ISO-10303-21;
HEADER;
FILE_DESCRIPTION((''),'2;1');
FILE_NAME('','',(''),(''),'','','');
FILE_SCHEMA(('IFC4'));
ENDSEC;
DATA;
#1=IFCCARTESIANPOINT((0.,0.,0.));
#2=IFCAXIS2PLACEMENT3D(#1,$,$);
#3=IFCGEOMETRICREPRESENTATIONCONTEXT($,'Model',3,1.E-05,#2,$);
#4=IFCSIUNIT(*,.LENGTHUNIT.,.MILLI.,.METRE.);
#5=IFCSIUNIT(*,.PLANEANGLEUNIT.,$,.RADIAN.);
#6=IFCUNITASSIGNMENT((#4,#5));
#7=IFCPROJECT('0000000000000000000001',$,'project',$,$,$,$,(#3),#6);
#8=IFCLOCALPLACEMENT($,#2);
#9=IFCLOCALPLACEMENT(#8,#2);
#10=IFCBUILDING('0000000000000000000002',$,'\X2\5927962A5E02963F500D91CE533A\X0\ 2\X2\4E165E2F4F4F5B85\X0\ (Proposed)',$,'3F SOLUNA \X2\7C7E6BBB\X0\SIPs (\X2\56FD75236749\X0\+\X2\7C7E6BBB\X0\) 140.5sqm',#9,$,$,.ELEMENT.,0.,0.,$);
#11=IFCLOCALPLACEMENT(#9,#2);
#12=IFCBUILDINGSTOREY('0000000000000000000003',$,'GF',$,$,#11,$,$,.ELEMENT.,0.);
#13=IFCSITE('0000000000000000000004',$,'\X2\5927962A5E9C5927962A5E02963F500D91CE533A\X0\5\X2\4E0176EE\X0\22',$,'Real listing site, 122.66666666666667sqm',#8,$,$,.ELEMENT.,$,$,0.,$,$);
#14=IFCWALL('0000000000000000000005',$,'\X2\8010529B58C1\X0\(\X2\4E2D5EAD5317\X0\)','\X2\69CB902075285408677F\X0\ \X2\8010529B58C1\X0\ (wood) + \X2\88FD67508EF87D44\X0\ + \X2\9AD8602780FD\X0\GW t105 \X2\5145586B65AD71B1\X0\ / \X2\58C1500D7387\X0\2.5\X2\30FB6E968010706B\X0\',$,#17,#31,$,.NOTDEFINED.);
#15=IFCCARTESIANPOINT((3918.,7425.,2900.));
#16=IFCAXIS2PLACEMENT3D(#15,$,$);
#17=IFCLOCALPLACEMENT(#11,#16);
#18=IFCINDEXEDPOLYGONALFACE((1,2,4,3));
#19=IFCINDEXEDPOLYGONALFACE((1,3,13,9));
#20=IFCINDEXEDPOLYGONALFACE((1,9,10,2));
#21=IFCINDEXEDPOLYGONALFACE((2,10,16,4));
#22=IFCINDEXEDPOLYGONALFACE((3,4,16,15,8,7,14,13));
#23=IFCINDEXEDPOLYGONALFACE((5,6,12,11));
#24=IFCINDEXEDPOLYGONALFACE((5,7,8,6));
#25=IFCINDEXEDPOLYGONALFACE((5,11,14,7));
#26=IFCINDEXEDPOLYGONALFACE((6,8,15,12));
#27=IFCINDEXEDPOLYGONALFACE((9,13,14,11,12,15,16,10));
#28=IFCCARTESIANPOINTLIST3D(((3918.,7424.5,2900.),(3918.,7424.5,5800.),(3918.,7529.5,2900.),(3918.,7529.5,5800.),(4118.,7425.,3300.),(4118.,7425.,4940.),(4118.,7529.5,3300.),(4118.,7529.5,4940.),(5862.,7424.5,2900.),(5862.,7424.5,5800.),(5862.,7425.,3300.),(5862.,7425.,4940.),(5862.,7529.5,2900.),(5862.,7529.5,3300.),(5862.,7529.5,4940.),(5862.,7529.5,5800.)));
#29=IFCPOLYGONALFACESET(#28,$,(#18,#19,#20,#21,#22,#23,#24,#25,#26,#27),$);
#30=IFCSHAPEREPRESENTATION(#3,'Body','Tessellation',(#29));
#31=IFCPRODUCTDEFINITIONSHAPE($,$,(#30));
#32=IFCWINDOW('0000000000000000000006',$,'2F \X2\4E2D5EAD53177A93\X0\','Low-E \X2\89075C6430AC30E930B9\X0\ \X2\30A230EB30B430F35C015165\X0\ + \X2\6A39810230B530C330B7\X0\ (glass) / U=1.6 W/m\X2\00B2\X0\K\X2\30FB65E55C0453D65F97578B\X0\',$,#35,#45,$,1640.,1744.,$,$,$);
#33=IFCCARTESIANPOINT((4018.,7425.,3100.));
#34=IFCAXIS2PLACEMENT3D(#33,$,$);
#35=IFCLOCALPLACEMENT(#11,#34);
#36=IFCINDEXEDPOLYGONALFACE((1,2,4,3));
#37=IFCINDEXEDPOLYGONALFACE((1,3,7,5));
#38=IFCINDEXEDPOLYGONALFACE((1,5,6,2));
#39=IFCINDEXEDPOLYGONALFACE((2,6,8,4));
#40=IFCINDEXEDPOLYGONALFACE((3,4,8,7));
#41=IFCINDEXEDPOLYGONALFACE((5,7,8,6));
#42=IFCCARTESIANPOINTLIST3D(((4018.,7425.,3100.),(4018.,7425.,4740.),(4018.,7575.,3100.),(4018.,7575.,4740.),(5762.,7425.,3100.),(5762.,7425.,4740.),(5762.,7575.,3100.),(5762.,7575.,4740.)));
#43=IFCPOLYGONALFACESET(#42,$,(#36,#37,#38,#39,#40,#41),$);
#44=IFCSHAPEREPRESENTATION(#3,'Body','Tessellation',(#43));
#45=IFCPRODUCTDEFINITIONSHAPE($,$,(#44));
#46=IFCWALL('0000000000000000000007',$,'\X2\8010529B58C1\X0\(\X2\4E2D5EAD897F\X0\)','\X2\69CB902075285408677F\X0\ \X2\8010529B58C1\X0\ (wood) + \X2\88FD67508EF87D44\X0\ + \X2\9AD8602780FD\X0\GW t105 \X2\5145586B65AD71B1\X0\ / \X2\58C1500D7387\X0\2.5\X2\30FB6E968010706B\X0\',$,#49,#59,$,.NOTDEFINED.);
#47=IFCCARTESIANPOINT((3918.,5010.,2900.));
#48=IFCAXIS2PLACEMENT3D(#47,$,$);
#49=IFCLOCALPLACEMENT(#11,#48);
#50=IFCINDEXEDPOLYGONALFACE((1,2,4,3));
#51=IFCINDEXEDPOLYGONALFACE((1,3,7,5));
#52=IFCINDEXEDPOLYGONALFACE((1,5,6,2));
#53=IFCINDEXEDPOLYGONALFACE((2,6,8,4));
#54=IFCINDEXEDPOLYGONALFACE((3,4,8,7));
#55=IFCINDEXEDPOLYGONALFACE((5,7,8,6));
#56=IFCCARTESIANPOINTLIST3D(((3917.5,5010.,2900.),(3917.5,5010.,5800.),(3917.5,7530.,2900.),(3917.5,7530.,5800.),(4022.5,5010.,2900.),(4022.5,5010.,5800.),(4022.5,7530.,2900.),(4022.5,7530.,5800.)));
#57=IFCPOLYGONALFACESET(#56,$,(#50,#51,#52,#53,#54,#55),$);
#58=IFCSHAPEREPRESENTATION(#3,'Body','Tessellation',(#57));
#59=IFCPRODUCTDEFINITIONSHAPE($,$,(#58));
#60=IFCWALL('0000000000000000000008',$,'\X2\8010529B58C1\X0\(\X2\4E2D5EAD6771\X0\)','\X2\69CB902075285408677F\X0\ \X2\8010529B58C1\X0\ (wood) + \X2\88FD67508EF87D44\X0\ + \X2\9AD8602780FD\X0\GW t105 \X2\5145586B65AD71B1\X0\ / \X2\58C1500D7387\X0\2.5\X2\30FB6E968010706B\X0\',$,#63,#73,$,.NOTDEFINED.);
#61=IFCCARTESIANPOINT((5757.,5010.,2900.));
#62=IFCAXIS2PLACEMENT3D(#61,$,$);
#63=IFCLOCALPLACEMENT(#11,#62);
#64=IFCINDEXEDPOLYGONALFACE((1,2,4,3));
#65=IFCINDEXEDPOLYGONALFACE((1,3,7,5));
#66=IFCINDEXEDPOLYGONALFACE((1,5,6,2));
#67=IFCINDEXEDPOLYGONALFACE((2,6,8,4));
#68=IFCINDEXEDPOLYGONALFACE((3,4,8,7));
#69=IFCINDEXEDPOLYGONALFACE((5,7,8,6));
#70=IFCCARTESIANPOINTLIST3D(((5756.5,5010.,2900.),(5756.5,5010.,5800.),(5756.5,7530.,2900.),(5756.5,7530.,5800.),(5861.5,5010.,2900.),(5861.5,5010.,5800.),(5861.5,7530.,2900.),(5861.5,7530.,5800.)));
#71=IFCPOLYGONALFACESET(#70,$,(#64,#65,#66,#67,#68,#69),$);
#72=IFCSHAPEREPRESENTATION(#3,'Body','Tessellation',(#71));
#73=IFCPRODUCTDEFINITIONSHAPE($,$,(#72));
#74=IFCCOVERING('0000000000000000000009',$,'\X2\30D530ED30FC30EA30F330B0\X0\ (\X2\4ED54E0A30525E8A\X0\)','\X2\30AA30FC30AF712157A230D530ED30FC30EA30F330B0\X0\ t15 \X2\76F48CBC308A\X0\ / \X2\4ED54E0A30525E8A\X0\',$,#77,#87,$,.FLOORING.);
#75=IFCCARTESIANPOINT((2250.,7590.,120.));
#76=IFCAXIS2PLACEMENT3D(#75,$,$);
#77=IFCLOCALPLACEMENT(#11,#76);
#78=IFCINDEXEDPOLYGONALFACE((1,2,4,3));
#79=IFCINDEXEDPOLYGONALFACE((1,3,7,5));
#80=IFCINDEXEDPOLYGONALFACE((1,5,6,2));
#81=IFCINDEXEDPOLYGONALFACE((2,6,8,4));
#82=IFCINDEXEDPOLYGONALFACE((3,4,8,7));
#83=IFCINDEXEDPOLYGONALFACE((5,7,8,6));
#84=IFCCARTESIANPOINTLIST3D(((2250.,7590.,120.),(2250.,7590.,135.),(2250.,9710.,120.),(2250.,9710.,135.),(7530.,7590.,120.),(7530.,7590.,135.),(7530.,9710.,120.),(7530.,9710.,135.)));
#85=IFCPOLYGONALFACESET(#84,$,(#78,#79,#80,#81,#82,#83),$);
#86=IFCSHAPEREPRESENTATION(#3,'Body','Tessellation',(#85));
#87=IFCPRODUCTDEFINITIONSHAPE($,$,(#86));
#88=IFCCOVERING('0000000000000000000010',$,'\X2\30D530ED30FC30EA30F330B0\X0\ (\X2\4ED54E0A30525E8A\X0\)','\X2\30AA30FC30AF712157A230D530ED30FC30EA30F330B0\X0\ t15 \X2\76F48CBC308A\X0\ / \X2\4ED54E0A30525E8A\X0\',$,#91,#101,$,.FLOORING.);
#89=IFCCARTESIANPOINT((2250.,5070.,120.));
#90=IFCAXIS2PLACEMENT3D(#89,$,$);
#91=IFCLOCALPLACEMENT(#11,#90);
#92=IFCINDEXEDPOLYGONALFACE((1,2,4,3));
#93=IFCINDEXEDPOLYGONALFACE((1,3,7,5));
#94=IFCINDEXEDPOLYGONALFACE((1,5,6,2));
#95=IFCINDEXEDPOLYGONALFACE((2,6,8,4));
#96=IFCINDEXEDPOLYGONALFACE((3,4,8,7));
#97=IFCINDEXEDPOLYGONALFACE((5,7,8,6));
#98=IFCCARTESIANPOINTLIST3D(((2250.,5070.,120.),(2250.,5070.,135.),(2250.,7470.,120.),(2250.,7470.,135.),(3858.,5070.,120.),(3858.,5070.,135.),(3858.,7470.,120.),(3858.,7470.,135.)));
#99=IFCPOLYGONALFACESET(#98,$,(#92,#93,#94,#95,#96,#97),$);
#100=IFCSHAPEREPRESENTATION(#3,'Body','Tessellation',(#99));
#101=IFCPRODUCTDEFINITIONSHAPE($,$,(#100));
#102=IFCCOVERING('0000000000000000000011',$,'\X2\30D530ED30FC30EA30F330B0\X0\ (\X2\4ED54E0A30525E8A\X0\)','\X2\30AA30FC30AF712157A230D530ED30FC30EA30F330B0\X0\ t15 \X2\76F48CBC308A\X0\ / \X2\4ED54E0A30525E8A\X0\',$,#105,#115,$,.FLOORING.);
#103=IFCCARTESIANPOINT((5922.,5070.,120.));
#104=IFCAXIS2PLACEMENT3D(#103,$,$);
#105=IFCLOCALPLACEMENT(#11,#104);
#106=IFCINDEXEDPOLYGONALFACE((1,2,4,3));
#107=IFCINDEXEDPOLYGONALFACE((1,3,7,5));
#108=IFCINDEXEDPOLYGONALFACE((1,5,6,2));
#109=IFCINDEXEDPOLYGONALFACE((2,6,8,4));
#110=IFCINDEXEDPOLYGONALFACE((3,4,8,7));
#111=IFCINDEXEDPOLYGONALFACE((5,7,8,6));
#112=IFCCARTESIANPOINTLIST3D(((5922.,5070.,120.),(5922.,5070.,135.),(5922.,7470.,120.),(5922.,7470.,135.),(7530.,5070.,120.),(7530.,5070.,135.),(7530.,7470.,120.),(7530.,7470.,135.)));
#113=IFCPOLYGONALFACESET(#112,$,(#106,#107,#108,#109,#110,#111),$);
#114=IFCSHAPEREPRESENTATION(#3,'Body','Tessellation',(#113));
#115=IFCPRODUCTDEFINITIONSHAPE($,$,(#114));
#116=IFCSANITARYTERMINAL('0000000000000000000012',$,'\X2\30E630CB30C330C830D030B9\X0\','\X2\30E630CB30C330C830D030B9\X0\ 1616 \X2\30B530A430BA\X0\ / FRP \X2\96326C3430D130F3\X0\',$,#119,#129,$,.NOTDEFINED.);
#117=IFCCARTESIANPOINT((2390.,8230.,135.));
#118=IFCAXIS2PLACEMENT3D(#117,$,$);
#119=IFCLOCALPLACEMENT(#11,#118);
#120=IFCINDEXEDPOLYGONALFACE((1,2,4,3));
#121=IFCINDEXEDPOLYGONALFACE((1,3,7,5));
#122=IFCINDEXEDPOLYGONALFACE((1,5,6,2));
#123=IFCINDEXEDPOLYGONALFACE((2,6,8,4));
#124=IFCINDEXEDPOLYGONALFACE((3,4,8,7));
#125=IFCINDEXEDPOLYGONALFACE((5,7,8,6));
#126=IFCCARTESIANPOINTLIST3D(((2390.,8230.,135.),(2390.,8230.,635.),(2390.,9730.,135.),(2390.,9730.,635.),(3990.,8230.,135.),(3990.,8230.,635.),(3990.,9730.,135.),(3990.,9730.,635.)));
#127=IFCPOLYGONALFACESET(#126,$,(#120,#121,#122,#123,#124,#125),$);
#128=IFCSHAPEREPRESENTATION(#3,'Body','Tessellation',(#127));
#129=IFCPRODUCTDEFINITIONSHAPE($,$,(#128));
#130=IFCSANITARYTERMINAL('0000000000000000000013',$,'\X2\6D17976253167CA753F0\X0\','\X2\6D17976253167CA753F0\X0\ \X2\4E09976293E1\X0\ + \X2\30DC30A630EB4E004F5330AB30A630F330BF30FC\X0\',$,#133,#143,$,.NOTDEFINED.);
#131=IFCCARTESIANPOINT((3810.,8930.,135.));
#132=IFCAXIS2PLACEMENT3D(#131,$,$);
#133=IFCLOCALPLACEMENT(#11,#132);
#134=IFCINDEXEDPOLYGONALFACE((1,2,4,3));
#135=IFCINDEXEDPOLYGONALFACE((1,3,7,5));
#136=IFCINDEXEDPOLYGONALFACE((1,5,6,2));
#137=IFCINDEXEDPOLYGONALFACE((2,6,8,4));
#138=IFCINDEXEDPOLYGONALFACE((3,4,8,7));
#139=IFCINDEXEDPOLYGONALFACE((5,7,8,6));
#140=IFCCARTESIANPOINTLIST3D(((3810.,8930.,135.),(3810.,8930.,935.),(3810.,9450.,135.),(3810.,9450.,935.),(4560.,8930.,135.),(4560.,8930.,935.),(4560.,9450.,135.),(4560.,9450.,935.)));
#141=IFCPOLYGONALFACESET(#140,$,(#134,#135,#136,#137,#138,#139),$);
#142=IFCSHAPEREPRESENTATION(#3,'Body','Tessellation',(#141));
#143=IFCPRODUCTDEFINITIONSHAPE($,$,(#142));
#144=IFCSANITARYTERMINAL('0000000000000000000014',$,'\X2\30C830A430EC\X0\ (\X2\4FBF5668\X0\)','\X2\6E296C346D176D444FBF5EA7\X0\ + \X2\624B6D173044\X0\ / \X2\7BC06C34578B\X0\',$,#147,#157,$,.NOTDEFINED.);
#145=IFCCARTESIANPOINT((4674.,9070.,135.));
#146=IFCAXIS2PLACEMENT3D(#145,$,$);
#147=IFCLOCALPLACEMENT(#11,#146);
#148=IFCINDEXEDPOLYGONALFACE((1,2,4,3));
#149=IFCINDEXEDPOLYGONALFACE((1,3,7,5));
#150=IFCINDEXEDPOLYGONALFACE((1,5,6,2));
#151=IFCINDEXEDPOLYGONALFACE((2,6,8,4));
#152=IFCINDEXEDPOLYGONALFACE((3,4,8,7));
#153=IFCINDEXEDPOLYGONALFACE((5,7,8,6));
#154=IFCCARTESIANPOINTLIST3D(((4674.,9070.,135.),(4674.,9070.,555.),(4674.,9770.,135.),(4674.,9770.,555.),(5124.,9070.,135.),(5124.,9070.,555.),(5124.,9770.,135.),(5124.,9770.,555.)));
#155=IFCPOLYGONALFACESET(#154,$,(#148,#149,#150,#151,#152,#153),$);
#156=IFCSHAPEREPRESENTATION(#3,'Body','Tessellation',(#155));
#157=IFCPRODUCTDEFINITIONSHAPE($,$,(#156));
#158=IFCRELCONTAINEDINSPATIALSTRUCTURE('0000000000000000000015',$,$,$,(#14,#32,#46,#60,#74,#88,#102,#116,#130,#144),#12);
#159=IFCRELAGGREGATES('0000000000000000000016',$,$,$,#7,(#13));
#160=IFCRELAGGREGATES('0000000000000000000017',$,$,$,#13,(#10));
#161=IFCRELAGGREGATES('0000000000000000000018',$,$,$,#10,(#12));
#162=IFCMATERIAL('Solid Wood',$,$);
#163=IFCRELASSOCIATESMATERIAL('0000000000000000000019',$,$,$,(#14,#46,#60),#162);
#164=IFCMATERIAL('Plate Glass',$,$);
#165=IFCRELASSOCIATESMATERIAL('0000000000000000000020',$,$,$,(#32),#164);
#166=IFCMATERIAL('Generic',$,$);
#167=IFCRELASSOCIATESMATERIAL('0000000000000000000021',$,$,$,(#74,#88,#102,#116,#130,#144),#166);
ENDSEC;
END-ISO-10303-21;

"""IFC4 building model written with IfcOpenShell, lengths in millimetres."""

from ifc_helpers import new_model, si_unit, frame, frame_2d, origin, place, context, project, spatial, rectangle, extrude, material, element, fill, save


model = new_model("IFC4")

# Units and contexts
model_context = context("Model", 3, precision=1e-05, world=origin())
ifc_project = project(units=[si_unit("LENGTHUNIT", "METRE", prefix="MILLI"), si_unit("PLANEANGLEUNIT", "RADIAN")], contexts=[model_context])

# Site, building, storey
site_placement = place(None, origin())
site = spatial("IfcSite", under=ifc_project, at=site_placement, Name="大阪府大阪市阿倍野区5丁目22", ObjectType="Real listing site, 122.66666666666667sqm", CompositionType="ELEMENT", RefElevation=0.0)
building_placement = place(site_placement, origin())
building = spatial("IfcBuilding", under=site, at=building_placement, Name="大阪市阿倍野区 2世帯住宅 (Proposed)", ObjectType="3F SOLUNA 籾殻SIPs (国産杉+籾殻) 140.5sqm", CompositionType="ELEMENT", ElevationOfRefHeight=0.0, ElevationOfTerrain=0.0)
storey_placement = place(building_placement, origin())
storey = spatial("IfcBuildingStorey", under=building, at=storey_placement, Name="GF", CompositionType="ELEMENT", Elevation=0.0)

# Shared definitions
ifc_material_1 = material(Name="Solid Wood")

# Shared definitions
ifc_material_2 = material(Name="Plate Glass")

# Wall, opening, window
wall_1_placement = place(storey_placement, frame((3918.0, 7425.0, 2900.0)))
wall_1 = element("IfcWall", 1, at=wall_1_placement, inside=storey, material=ifc_material_1, Name="耐力壁(中庭北)", Description="構造用合板 耐力壁 (wood) + 製材軸組 + 高性能GW t105 充填断熱 / 壁倍率2.5・準耐火", PredefinedType="NOTDEFINED", context=model_context, shape_type="SweptSolid", body=[
    extrude(rectangle(XDim=1944.0, YDim=105.0, at=frame_2d((972.0, 52.0))), frame((3918.0, 7425.0, 2900.0)), (0.0, 0.0, 1.0), 2900.0),
])
opening_1_placement = place(storey_placement, frame((4018.0, 7425.0, 3100.0)))
opening_1 = element("IfcOpeningElement", 2, at=opening_1_placement, cuts=wall_1, PredefinedType="NOTDEFINED", context=model_context, shape_type="SweptSolid", body=[
    extrude(rectangle(XDim=1744.0, YDim=150.0, at=frame_2d((872.0, 75.0))), frame((4018.0, 7425.0, 3100.0)), (0.0, 0.0, 1.0), 1640.0),
])
window_1_placement = place(storey_placement, frame((4018.0, 7425.0, 3100.0)))
window_1 = element("IfcWindow", 3, at=window_1_placement, inside=storey, material=ifc_material_2, Name="2F 中庭北窓", Description="Low-E 複層ガラス アルゴン封入 + 樹脂サッシ (glass) / U=1.6 W/m²K・日射取得型", OverallHeight=1640.0, OverallWidth=1744.0, context=model_context, shape_type="SweptSolid", body=[
    extrude(rectangle(XDim=1744.0, YDim=150.0, at=frame_2d((872.0, 75.0))), frame((4018.0, 7425.0, 3100.0)), (0.0, 0.0, 1.0), 1640.0),
])
fill(opening_1, window_1)

# Walls
wall_2_placement = place(storey_placement, frame((3918.0, 5010.0, 2900.0)))
element("IfcWall", 4, at=wall_2_placement, inside=storey, material=ifc_material_1, Name="耐力壁(中庭西)", Description="構造用合板 耐力壁 (wood) + 製材軸組 + 高性能GW t105 充填断熱 / 壁倍率2.5・準耐火", PredefinedType="NOTDEFINED", context=model_context, shape_type="SweptSolid", body=[
    extrude(rectangle(XDim=105.0, YDim=2520.0, at=frame_2d((52.0, 1260.0))), frame((3918.0, 5010.0, 2900.0)), (0.0, 0.0, 1.0), 2900.0),
])
wall_3_placement = place(storey_placement, frame((5757.0, 5010.0, 2900.0)))
element("IfcWall", 5, at=wall_3_placement, inside=storey, material=ifc_material_1, Name="耐力壁(中庭東)", Description="構造用合板 耐力壁 (wood) + 製材軸組 + 高性能GW t105 充填断熱 / 壁倍率2.5・準耐火", PredefinedType="NOTDEFINED", context=model_context, shape_type="SweptSolid", body=[
    extrude(rectangle(XDim=105.0, YDim=2520.0, at=frame_2d((52.0, 1260.0))), frame((5757.0, 5010.0, 2900.0)), (0.0, 0.0, 1.0), 2900.0),
])

# Coverings
ifc_material_3 = material(Name="Generic")
covering_1_placement = place(storey_placement, frame((2250.0, 7590.0, 120.0)))
element("IfcCovering", 6, at=covering_1_placement, inside=storey, material=ifc_material_3, Name="フローリング (仕上げ床)", Description="オーク無垢フローリング t15 直貼り / 仕上げ床", PredefinedType="FLOORING", context=model_context, shape_type="SweptSolid", body=[
    extrude(rectangle(XDim=5280.0, YDim=2120.0, at=frame_2d((2640.0, 1060.0))), frame((2250.0, 7590.0, 120.0)), (0.0, 0.0, 1.0), 15.0),
])
covering_2_placement = place(storey_placement, frame((2250.0, 5070.0, 120.0)))
element("IfcCovering", 7, at=covering_2_placement, inside=storey, material=ifc_material_3, Name="フローリング (仕上げ床)", Description="オーク無垢フローリング t15 直貼り / 仕上げ床", PredefinedType="FLOORING", context=model_context, shape_type="SweptSolid", body=[
    extrude(rectangle(XDim=1608.0, YDim=2400.0, at=frame_2d((804.0, 1200.0))), frame((2250.0, 5070.0, 120.0)), (0.0, 0.0, 1.0), 15.0),
])
covering_3_placement = place(storey_placement, frame((5922.0, 5070.0, 120.0)))
element("IfcCovering", 8, at=covering_3_placement, inside=storey, material=ifc_material_3, Name="フローリング (仕上げ床)", Description="オーク無垢フローリング t15 直貼り / 仕上げ床", PredefinedType="FLOORING", context=model_context, shape_type="SweptSolid", body=[
    extrude(rectangle(XDim=1608.0, YDim=2400.0, at=frame_2d((804.0, 1200.0))), frame((5922.0, 5070.0, 120.0)), (0.0, 0.0, 1.0), 15.0),
])

# Sanitary terminals
sanitary_terminal_1_placement = place(storey_placement, frame((2390.0, 8230.0, 135.0)))
element("IfcSanitaryTerminal", 9, at=sanitary_terminal_1_placement, inside=storey, material=ifc_material_3, Name="ユニットバス", Description="ユニットバス 1616 サイズ / FRP 防水パン", PredefinedType="NOTDEFINED", context=model_context, shape_type="SweptSolid", body=[
    extrude(rectangle(XDim=1600.0, YDim=1500.0, at=frame_2d((800.0, 750.0))), frame((2390.0, 8230.0, 135.0)), (0.0, 0.0, 1.0), 500.0),
])
sanitary_terminal_2_placement = place(storey_placement, frame((3810.0, 8930.0, 135.0)))
element("IfcSanitaryTerminal", 10, at=sanitary_terminal_2_placement, inside=storey, material=ifc_material_3, Name="洗面化粧台", Description="洗面化粧台 三面鏡 + ボウル一体カウンター", PredefinedType="NOTDEFINED", context=model_context, shape_type="SweptSolid", body=[
    extrude(rectangle(XDim=750.0, YDim=520.0, at=frame_2d((375.0, 260.0))), frame((3810.0, 8930.0, 135.0)), (0.0, 0.0, 1.0), 800.0),
])
sanitary_terminal_3_placement = place(storey_placement, frame((4674.0, 9070.0, 135.0)))
element("IfcSanitaryTerminal", 11, at=sanitary_terminal_3_placement, inside=storey, material=ifc_material_3, Name="トイレ (便器)", Description="温水洗浄便座 + 手洗い / 節水型", PredefinedType="NOTDEFINED", context=model_context, shape_type="SweptSolid", body=[
    extrude(rectangle(XDim=450.0, YDim=700.0, at=frame_2d((225.0, 350.0))), frame((4674.0, 9070.0, 135.0)), (0.0, 0.0, 1.0), 420.0),
])

save(model, "model.ifc")
